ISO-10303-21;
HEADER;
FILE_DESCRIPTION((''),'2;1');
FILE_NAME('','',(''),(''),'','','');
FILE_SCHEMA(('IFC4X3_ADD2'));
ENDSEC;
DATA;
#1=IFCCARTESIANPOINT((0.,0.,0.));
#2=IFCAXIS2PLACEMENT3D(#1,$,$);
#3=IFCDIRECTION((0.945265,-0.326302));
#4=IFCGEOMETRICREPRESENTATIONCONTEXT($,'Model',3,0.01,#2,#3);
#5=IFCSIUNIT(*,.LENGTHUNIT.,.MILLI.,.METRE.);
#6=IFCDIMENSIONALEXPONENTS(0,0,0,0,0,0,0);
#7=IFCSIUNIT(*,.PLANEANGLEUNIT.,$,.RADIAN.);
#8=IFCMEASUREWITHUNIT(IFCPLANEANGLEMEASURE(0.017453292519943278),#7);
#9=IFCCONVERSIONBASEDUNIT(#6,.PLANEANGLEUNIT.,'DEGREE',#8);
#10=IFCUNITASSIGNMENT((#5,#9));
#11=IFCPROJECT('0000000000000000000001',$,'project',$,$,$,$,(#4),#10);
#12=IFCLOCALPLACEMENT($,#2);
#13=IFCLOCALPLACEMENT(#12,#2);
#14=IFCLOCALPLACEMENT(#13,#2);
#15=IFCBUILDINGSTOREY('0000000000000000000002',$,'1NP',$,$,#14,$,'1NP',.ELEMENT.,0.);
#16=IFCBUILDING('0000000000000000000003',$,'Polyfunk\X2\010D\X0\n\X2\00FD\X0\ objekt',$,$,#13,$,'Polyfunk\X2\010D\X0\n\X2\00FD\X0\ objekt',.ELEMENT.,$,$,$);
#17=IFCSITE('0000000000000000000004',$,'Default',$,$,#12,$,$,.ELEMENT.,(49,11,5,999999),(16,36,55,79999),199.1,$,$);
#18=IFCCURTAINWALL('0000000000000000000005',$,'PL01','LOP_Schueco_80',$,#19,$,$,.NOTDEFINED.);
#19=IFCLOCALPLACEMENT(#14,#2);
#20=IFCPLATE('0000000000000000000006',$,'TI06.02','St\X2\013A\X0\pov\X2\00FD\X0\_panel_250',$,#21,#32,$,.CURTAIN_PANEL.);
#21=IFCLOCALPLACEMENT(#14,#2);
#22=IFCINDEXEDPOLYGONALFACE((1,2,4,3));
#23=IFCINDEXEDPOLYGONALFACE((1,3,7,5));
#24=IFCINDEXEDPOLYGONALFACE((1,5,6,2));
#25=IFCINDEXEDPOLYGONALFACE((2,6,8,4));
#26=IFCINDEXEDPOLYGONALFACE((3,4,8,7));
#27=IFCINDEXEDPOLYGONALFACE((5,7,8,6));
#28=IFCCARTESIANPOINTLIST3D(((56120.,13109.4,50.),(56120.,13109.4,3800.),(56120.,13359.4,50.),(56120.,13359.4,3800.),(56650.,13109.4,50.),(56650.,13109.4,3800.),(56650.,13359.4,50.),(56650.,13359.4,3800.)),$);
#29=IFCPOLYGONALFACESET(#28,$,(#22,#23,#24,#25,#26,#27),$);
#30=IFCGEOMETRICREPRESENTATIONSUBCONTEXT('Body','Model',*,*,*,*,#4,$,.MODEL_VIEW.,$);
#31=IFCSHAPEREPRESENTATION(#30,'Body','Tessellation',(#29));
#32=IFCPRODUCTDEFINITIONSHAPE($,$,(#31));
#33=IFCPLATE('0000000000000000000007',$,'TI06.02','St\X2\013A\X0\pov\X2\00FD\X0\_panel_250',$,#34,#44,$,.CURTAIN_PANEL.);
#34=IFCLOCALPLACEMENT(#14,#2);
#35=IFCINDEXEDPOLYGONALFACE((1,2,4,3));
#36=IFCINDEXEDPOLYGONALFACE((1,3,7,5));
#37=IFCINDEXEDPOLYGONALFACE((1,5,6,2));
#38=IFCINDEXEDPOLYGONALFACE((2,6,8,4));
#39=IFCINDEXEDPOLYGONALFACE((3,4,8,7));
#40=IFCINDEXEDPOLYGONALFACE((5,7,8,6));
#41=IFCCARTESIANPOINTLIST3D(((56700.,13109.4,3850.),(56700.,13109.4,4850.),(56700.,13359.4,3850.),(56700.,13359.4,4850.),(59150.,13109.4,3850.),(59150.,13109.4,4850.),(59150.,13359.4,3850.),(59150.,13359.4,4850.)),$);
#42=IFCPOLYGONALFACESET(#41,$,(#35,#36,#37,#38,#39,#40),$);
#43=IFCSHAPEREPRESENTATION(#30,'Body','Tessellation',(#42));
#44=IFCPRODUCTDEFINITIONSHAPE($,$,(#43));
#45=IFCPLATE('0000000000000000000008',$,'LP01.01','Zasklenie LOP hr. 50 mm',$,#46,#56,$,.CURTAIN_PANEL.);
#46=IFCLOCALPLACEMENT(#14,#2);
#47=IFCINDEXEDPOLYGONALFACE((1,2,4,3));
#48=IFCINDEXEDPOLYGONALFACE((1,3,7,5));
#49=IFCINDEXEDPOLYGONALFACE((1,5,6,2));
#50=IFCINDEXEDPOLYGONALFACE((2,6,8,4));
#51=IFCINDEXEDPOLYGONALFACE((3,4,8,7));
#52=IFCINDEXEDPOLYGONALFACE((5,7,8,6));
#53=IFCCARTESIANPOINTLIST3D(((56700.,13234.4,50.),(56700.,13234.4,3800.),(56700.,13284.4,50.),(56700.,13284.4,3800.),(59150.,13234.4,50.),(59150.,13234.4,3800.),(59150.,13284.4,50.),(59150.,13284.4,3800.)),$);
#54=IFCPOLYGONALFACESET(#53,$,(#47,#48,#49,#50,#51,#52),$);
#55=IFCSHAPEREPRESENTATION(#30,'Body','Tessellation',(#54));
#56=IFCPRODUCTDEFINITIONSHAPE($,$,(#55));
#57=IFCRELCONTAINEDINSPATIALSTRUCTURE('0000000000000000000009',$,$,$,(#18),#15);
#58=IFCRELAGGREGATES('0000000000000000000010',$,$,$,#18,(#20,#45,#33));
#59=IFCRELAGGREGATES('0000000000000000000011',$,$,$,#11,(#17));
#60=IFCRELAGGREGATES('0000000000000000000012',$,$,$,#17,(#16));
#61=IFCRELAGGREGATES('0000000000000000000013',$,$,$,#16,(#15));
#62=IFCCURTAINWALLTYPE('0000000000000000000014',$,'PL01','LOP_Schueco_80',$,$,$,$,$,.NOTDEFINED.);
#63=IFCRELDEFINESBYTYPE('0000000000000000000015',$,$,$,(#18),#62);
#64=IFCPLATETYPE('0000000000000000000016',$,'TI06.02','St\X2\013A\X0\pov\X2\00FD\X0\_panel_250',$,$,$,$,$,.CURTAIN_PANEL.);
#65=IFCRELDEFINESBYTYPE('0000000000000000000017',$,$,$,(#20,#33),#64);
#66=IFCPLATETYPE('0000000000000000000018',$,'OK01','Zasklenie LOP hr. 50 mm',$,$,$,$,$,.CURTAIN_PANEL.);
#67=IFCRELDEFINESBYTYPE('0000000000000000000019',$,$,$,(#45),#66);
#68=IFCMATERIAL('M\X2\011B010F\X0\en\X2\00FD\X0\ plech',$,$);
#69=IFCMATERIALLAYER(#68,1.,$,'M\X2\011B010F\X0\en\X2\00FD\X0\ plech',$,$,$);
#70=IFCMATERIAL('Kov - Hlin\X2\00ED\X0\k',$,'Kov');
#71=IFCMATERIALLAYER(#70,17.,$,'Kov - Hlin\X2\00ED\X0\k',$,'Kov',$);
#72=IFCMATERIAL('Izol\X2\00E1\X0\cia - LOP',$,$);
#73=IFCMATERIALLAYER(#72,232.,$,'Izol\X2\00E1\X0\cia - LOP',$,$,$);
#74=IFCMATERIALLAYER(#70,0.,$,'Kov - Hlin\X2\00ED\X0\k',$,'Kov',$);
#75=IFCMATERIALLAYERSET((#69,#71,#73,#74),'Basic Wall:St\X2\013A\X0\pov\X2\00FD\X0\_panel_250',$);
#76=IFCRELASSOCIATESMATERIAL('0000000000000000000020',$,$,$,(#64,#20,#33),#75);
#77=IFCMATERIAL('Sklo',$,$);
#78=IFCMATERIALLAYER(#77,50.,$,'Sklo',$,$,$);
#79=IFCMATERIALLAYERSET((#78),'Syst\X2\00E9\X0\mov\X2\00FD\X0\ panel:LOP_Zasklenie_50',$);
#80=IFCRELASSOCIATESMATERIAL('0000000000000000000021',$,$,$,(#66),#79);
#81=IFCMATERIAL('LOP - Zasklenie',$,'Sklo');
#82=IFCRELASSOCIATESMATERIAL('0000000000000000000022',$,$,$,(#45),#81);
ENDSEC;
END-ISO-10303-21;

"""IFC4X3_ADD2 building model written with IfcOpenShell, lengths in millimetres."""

from ifc_helpers import new_model, entity, si_unit, converted_unit, direction, frame, frame_2d, origin, place, context, subcontext, project, spatial, rectangle, extrude, source, transform, mapped, material, layer, layer_set, layer_usage, type_object, type_shapes, element, aggregate, save


model = new_model("IFC4X3_ADD2")

# Units and contexts
model_context = context("Model", 3, precision=0.01, world=origin(), true_north=direction((0.945265, -0.326302)))
body_context = subcontext(model_context, "Body", "Model", "MODEL_VIEW")
ifc_project = project(units=[si_unit("LENGTHUNIT", "METRE", prefix="MILLI"), converted_unit("PLANEANGLEUNIT", "DEGREE", entity("IfcPlaneAngleMeasure", 0.017453292519943278), si_unit("PLANEANGLEUNIT", "RADIAN"), dimensions=[0, 0, 0, 0, 0, 0, 0])], contexts=[model_context])

# Site, building, storey
site_placement = place(None, origin())
site = spatial("IfcSite", under=ifc_project, at=site_placement, Name="Default", CompositionType="ELEMENT", RefLatitude=(49, 11, 5, 999999), RefLongitude=(16, 36, 55, 79999), RefElevation=199.1)
building_placement = place(site_placement, origin())
building = spatial("IfcBuilding", under=site, at=building_placement, Name="Polyfunkčný objekt", LongName="Polyfunkčný objekt", CompositionType="ELEMENT")
storey_placement = place(building_placement, origin())
storey = spatial("IfcBuildingStorey", under=building, at=storey_placement, Name="1NP", LongName="1NP", CompositionType="ELEMENT", Elevation=0.0)

# Curtain wall, plates
curtain_wall_type = type_object("IfcCurtainWallType", Name="PL01", Description="LOP_Schueco_80", PredefinedType="NOTDEFINED")
curtain_wall_placement = place(storey_placement, origin())
curtain_wall = element("IfcCurtainWall", 1, at=curtain_wall_placement, inside=storey, type_object=curtain_wall_type, Name="PL01", Description="LOP_Schueco_80", PredefinedType="NOTDEFINED")
ifc_material_1 = material(Name="Měďený plech")
ifc_layer_1 = layer(ifc_material_1, 1.0, Name="Měďený plech")
ifc_material_2 = material(Name="Kov - Hliník", Category="Kov")
ifc_layer_2 = layer(ifc_material_2, 17.0, Name="Kov - Hliník", Category="Kov")
ifc_material_3 = material(Name="Izolácia - LOP")
ifc_layer_3 = layer(ifc_material_3, 232.0, Name="Izolácia - LOP")
ifc_layer_4 = layer(ifc_material_2, 0.0, Name="Kov - Hliník", Category="Kov")
ifc_layer_set_1 = layer_set([ifc_layer_1, ifc_layer_2, ifc_layer_3, ifc_layer_4], Name="Basic Wall:Stĺpový_panel_250")
ifc_layer_usage_1 = layer_usage(ifc_layer_set_1, "AXIS2", "NEGATIVE", 125.0)
plate_type_1 = type_object("IfcPlateType", Name="TI06.02", Description="Stĺpový_panel_250", PredefinedType="CURTAIN_PANEL", material=ifc_layer_set_1)
plate_1_placement = place(storey_placement, frame((56120.0, 13234.4, 50.0)))
plate_1 = element("IfcPlate", 2, at=plate_1_placement, type_object=plate_type_1, material=ifc_layer_usage_1, Name="TI06.02", Description="Stĺpový_panel_250", PredefinedType="CURTAIN_PANEL", context=body_context, shape_type="SweptSolid", body=[
    extrude(rectangle(XDim=250.0, YDim=530.0, at=frame_2d((0.0, 0.0), x_axis=(1.0, 0.0))), frame((265.0, 0.0, 0.0), z_axis=(0.0, 0.0, 1.0), x_axis=(0.0, 1.0, 0.0)), (0.0, 0.0, 1.0), 3750.0),
])
ifc_layer_usage_2 = layer_usage(ifc_layer_set_1, "AXIS2", "NEGATIVE", 125.0)
plate_2_placement = place(storey_placement, frame((56700.0, 13234.4, 3850.0)))
plate_2 = element("IfcPlate", 3, at=plate_2_placement, type_object=plate_type_1, material=ifc_layer_usage_2, Name="TI06.02", Description="Stĺpový_panel_250", PredefinedType="CURTAIN_PANEL", context=body_context, shape_type="SweptSolid", body=[
    extrude(rectangle(XDim=250.0, YDim=2450.0, at=frame_2d((0.0, 0.0), x_axis=(1.0, 0.0))), frame((1225.0, 0.0, 0.0), z_axis=(0.0, 0.0, 1.0), x_axis=(0.0, 1.0, 0.0)), (0.0, 0.0, 1.0), 1000.0),
])
ifc_material_4 = material(Name="LOP - Zasklenie", Category="Sklo")
ifc_material_5 = material(Name="Sklo")
ifc_layer_5 = layer(ifc_material_5, 50.0, Name="Sklo")
ifc_layer_set_2 = layer_set([ifc_layer_5], Name="Systémový panel:LOP_Zasklenie_50")
plate_type_2 = type_object("IfcPlateType", Name="OK01", Description="Zasklenie LOP hr. 50 mm", PredefinedType="CURTAIN_PANEL", material=ifc_layer_set_2)
shared_shape_1 = source(origin(), body_context, "Body", "SweptSolid", [
    extrude(rectangle(XDim=3750.0, YDim=2450.0, at=frame_2d((-141.7, 0.0), x_axis=(1.0, 0.0))), frame((0.0, 0.0, 2016.7), z_axis=(0.0, 1.0, 0.0), x_axis=(0.0, 0.0, 1.0)), (0.0, 0.0, 1.0), 50.0),
])
type_shapes(plate_type_2, [shared_shape_1])
plate_3_placement = place(curtain_wall_placement, frame((57925.0, 13234.4, 50.0)))
plate_3 = element("IfcPlate", 4, at=plate_3_placement, type_object=plate_type_2, material=ifc_material_4, Name="LP01.01", Description="Zasklenie LOP hr. 50 mm", PredefinedType="CURTAIN_PANEL", context=body_context, shape_type="MappedRepresentation", body=[
    mapped(shared_shape_1, transform((0.0, 0.0, 0.0), scale=1.0)),
])
aggregate(curtain_wall, [plate_1, plate_3, plate_2])

save(model, "model.ifc")
